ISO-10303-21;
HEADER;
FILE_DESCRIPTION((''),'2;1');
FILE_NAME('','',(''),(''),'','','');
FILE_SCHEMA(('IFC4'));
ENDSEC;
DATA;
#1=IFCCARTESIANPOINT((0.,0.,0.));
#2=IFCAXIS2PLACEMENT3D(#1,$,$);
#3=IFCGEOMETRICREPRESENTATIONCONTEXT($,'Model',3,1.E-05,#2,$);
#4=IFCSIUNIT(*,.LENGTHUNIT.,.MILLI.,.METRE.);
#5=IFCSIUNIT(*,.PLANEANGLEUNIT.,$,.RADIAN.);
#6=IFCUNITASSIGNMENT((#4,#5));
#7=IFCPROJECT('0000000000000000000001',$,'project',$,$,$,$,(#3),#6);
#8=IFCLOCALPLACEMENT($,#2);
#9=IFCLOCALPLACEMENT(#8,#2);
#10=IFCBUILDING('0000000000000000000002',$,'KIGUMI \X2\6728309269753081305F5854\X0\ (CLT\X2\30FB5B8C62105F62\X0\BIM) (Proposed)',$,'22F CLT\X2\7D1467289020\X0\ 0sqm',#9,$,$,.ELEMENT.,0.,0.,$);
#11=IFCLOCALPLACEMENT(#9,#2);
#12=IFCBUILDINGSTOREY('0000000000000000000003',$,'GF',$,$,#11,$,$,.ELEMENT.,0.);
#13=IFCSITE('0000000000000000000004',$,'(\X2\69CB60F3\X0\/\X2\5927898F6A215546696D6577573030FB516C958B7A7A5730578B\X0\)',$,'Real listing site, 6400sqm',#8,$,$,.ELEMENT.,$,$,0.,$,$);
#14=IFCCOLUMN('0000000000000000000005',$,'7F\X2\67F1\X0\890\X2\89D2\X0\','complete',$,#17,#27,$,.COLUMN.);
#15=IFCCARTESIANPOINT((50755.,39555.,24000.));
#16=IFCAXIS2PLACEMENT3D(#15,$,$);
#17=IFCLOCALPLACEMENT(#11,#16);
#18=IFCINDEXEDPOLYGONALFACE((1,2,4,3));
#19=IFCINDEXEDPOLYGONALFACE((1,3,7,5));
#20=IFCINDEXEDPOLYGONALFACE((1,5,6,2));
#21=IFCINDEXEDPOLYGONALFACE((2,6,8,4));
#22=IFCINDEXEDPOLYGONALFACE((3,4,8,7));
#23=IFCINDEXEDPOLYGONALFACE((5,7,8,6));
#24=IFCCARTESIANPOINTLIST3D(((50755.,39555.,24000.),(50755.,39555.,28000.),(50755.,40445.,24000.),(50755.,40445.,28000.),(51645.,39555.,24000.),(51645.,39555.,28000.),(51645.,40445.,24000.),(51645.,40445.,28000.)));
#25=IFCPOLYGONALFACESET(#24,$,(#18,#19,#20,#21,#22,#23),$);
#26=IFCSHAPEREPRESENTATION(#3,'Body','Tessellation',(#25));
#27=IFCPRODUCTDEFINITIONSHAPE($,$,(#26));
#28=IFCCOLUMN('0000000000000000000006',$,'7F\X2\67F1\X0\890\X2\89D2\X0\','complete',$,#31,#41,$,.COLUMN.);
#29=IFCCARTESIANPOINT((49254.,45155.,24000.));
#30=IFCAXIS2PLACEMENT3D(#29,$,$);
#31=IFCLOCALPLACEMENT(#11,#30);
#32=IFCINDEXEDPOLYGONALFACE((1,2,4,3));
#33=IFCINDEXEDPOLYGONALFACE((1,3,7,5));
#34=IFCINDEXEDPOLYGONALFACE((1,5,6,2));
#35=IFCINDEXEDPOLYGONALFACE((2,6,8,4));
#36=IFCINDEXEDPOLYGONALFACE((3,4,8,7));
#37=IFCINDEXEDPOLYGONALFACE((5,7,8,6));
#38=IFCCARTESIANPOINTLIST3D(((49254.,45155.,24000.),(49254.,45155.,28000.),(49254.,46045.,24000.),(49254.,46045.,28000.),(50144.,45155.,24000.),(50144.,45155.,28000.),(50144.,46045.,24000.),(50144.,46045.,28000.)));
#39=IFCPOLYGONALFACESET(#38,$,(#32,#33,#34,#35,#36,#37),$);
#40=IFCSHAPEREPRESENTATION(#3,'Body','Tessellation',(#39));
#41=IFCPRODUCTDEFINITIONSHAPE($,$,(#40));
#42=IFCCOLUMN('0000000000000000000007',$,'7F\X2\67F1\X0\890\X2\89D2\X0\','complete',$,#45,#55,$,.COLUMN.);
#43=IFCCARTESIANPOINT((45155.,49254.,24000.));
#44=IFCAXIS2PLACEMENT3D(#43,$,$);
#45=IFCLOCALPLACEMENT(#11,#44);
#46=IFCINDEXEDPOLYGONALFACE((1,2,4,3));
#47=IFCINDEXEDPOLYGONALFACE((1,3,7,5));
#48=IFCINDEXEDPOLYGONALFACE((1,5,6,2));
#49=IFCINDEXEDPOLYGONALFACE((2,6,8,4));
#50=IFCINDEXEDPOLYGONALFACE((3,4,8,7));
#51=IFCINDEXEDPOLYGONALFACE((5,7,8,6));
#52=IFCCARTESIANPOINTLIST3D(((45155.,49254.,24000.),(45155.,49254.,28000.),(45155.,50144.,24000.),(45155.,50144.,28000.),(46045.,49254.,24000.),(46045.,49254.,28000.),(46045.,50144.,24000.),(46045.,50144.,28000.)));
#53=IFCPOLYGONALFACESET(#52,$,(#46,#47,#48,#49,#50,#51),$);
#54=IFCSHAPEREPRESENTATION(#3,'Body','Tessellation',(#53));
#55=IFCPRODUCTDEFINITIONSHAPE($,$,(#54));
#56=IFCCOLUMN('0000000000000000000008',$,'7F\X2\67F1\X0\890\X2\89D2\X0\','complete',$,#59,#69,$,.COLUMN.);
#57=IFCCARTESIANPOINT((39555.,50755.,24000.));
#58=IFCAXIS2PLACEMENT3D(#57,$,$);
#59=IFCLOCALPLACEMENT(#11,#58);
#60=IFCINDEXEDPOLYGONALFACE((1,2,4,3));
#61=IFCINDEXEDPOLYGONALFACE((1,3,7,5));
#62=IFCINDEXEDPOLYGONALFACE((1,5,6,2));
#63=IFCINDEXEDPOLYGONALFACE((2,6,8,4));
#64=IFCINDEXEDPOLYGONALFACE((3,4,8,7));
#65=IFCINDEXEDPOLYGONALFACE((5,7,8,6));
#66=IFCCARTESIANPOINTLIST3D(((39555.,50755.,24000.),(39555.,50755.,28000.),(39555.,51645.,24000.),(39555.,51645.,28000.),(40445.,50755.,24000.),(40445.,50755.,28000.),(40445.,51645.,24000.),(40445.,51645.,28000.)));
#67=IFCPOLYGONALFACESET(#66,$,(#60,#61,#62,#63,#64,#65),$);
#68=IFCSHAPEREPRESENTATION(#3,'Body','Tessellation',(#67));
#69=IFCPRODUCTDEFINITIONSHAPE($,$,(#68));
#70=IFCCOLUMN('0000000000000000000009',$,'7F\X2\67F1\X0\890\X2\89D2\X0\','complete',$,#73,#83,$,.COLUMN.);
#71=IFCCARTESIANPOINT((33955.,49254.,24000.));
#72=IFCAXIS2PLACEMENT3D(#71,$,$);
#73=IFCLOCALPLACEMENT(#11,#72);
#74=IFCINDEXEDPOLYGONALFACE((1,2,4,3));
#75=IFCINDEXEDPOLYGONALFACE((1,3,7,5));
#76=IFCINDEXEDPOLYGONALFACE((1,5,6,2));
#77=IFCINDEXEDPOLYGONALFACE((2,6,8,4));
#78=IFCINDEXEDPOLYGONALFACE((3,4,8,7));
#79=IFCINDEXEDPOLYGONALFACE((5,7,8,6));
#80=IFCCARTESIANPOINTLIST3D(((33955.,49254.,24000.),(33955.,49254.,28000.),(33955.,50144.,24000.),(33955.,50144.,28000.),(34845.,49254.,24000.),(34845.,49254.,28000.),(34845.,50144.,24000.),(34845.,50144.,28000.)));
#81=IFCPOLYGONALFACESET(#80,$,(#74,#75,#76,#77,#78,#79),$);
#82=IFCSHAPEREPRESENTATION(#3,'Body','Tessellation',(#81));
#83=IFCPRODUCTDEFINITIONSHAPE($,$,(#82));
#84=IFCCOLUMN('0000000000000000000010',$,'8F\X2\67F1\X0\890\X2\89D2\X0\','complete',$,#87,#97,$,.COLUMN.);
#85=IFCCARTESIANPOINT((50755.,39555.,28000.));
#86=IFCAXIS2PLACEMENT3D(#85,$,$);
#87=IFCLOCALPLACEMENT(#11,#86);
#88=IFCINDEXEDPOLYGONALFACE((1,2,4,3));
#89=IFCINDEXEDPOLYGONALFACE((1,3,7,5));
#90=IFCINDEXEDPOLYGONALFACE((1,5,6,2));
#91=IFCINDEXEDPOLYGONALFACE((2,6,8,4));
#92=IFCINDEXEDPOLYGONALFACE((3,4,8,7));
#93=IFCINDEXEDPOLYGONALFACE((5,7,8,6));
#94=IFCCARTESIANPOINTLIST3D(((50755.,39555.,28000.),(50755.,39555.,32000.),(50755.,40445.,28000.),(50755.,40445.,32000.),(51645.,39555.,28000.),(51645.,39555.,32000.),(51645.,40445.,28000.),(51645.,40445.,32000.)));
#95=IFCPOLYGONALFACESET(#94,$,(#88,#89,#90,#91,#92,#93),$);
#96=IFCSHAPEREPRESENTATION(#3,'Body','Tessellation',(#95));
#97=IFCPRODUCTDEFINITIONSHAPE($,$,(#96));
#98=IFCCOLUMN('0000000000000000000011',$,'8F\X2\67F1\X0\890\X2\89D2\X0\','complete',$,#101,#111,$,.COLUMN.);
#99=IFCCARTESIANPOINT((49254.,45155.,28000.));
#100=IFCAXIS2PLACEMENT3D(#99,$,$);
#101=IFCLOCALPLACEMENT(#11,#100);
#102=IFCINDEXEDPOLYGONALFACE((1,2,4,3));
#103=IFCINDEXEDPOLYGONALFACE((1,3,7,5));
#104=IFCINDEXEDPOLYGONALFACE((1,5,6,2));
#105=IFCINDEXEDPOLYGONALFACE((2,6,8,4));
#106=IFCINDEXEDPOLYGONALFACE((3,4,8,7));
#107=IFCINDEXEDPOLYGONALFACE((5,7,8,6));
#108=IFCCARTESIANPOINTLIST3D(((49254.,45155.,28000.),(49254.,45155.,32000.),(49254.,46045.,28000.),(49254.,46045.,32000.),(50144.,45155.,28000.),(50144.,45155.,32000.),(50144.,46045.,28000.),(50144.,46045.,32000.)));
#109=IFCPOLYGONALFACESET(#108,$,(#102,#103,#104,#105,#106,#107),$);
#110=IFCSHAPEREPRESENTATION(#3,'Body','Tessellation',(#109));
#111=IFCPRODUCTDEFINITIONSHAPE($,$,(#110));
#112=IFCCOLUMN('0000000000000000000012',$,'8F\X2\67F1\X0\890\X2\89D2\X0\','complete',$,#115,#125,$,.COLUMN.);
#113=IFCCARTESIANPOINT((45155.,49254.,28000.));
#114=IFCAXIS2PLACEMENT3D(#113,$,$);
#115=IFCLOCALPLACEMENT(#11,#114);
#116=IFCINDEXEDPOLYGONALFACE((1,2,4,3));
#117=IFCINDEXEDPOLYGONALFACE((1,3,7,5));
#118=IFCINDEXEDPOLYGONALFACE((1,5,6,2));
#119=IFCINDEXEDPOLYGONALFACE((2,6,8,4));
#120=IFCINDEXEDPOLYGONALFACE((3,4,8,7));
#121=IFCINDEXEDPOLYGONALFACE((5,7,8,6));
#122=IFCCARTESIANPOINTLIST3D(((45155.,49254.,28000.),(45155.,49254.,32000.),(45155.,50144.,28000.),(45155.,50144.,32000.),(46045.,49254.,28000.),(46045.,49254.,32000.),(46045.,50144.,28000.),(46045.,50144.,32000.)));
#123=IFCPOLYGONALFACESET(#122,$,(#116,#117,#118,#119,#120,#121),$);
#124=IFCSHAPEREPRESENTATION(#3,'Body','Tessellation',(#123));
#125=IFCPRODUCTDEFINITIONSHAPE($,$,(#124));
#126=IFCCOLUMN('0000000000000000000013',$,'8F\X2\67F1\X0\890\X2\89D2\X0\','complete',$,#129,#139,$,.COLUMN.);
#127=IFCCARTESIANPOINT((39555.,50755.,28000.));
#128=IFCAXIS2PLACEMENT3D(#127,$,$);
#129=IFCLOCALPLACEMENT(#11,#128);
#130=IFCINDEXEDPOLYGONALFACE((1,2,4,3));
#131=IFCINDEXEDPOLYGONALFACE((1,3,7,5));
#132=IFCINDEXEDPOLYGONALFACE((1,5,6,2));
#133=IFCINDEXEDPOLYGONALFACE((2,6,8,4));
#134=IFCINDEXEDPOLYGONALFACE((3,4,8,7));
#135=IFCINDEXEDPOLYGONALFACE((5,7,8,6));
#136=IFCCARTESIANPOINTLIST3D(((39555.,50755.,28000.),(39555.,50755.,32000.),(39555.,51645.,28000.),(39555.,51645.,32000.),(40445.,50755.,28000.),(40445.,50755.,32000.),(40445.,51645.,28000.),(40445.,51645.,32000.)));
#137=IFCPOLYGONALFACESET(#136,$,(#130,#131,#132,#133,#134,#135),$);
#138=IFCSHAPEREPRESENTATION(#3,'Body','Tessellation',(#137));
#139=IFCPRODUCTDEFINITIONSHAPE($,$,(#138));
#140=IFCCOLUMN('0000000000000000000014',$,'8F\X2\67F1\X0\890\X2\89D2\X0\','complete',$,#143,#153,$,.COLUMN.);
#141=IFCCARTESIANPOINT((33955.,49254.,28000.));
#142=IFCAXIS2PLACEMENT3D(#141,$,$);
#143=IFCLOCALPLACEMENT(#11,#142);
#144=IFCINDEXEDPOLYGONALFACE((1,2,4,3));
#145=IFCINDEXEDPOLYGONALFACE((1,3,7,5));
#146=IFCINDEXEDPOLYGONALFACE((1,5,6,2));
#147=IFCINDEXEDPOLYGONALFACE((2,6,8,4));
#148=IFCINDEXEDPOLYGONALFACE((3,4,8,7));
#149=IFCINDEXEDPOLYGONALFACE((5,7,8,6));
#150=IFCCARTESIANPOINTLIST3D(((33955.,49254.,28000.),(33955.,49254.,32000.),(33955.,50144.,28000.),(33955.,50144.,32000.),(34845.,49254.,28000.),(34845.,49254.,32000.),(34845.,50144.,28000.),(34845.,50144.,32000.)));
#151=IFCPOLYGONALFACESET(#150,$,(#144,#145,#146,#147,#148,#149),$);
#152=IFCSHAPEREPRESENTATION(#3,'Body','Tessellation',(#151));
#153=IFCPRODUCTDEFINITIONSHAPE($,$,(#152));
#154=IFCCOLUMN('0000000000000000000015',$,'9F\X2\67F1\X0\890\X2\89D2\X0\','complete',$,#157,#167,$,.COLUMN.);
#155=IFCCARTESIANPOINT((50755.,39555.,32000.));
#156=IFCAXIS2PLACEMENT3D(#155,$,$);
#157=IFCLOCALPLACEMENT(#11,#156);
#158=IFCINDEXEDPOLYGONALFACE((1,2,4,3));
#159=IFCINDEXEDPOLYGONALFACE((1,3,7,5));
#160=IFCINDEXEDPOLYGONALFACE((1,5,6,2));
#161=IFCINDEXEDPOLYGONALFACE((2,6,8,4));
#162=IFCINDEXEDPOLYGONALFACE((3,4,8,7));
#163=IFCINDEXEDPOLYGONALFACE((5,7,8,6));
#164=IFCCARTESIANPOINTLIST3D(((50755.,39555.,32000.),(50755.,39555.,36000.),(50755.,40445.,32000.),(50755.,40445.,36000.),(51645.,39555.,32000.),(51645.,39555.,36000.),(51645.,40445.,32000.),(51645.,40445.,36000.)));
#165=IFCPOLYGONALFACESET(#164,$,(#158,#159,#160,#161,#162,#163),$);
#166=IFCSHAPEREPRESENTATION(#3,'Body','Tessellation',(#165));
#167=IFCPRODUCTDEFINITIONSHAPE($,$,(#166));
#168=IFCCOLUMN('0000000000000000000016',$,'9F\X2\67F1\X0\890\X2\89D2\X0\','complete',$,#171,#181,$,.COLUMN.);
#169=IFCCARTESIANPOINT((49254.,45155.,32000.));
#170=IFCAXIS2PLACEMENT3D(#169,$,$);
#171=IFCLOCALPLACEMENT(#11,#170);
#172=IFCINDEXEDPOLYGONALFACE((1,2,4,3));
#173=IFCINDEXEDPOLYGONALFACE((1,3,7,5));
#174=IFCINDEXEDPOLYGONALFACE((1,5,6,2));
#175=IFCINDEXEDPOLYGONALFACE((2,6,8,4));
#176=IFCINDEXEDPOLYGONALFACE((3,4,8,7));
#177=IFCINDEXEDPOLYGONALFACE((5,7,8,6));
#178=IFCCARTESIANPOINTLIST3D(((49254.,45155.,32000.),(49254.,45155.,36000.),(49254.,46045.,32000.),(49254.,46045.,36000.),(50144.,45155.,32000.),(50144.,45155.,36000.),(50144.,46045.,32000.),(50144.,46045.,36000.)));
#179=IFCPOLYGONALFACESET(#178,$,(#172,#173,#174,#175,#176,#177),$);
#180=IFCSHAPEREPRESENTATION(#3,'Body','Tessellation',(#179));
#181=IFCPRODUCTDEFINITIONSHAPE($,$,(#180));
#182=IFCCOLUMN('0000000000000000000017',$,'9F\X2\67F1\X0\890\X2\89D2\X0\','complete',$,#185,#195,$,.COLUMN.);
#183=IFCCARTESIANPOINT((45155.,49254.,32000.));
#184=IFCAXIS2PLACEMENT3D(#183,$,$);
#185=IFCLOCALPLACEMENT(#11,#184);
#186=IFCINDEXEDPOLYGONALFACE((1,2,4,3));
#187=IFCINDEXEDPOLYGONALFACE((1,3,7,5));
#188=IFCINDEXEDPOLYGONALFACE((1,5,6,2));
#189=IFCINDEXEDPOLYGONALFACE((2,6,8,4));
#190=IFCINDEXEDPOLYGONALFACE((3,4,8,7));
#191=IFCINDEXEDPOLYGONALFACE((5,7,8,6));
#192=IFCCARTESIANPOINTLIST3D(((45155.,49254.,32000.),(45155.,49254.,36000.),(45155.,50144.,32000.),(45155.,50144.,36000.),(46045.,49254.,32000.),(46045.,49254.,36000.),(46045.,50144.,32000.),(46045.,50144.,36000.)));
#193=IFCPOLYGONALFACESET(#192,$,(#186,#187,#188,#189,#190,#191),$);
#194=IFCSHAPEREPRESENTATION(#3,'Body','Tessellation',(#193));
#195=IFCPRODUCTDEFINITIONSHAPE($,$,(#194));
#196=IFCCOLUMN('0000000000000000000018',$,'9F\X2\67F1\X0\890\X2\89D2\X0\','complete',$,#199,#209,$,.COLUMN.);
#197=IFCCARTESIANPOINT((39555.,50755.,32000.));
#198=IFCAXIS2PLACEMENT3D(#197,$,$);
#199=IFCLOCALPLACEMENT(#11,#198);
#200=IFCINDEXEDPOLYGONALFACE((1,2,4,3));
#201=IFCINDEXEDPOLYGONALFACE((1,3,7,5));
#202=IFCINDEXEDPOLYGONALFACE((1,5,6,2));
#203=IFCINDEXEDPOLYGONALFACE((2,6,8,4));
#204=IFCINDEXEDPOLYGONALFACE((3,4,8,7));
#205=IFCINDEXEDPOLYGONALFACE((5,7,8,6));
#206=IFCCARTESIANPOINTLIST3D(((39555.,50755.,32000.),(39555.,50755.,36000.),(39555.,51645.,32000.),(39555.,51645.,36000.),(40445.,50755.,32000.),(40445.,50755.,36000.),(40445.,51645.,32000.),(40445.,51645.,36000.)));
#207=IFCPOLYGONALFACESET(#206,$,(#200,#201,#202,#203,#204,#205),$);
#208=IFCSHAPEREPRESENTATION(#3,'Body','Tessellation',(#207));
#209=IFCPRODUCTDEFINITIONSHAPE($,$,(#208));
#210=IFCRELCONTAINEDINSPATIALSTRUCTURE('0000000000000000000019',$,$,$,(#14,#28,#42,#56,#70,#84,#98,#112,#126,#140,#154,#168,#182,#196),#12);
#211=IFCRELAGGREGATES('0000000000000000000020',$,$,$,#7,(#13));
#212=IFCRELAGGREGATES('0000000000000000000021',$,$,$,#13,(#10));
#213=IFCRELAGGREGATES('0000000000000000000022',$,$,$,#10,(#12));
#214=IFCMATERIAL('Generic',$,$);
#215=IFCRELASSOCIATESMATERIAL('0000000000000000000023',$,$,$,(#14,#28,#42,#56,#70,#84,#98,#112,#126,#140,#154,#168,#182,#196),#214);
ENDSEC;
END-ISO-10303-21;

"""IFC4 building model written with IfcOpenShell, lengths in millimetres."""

from ifc_helpers import new_model, si_unit, frame, frame_2d, origin, place, context, project, spatial, rectangle, extrude, material, element, save


model = new_model("IFC4")

# Units and contexts
model_context = context("Model", 3, precision=1e-05, world=origin())
ifc_project = project(units=[si_unit("LENGTHUNIT", "METRE", prefix="MILLI"), si_unit("PLANEANGLEUNIT", "RADIAN")], contexts=[model_context])

# Site, building, storey
site_placement = place(None, origin())
site = spatial("IfcSite", under=ifc_project, at=site_placement, Name="(構想/大規模商業敷地・公開空地型)", ObjectType="Real listing site, 6400sqm", CompositionType="ELEMENT", RefElevation=0.0)
building_placement = place(site_placement, origin())
building = spatial("IfcBuilding", under=site, at=building_placement, Name="KIGUMI 木を極めた塔 (CLT・完成形BIM) (Proposed)", ObjectType="22F CLT純木造 0sqm", CompositionType="ELEMENT", ElevationOfRefHeight=0.0, ElevationOfTerrain=0.0)
storey_placement = place(building_placement, origin())
storey = spatial("IfcBuildingStorey", under=building, at=storey_placement, Name="GF", CompositionType="ELEMENT", Elevation=0.0)

# Columns
ifc_material = material(Name="Generic")
column_1_placement = place(storey_placement, frame((50755.0, 39555.0, 24000.0)))
element("IfcColumn", 1, at=column_1_placement, inside=storey, material=ifc_material, Name="7F柱890角", Description="complete", PredefinedType="COLUMN", context=model_context, shape_type="SweptSolid", body=[
    extrude(rectangle(XDim=890.0, YDim=890.0, at=frame_2d((445.0, 445.0))), frame((50755.0, 39555.0, 24000.0)), (0.0, 0.0, 1.0), 4000.0),
])
column_2_placement = place(storey_placement, frame((49254.0, 45155.0, 24000.0)))
element("IfcColumn", 2, at=column_2_placement, inside=storey, material=ifc_material, Name="7F柱890角", Description="complete", PredefinedType="COLUMN", context=model_context, shape_type="SweptSolid", body=[
    extrude(rectangle(XDim=890.0, YDim=890.0, at=frame_2d((445.0, 445.0))), frame((49254.0, 45155.0, 24000.0)), (0.0, 0.0, 1.0), 4000.0),
])
column_3_placement = place(storey_placement, frame((45155.0, 49254.0, 24000.0)))
element("IfcColumn", 3, at=column_3_placement, inside=storey, material=ifc_material, Name="7F柱890角", Description="complete", PredefinedType="COLUMN", context=model_context, shape_type="SweptSolid", body=[
    extrude(rectangle(XDim=890.0, YDim=890.0, at=frame_2d((445.0, 445.0))), frame((45155.0, 49254.0, 24000.0)), (0.0, 0.0, 1.0), 4000.0),
])
column_4_placement = place(storey_placement, frame((39555.0, 50755.0, 24000.0)))
element("IfcColumn", 4, at=column_4_placement, inside=storey, material=ifc_material, Name="7F柱890角", Description="complete", PredefinedType="COLUMN", context=model_context, shape_type="SweptSolid", body=[
    extrude(rectangle(XDim=890.0, YDim=890.0, at=frame_2d((445.0, 445.0))), frame((39555.0, 50755.0, 24000.0)), (0.0, 0.0, 1.0), 4000.0),
])
column_5_placement = place(storey_placement, frame((33955.0, 49254.0, 24000.0)))
element("IfcColumn", 5, at=column_5_placement, inside=storey, material=ifc_material, Name="7F柱890角", Description="complete", PredefinedType="COLUMN", context=model_context, shape_type="SweptSolid", body=[
    extrude(rectangle(XDim=890.0, YDim=890.0, at=frame_2d((445.0, 445.0))), frame((33955.0, 49254.0, 24000.0)), (0.0, 0.0, 1.0), 4000.0),
])
column_6_placement = place(storey_placement, frame((50755.0, 39555.0, 28000.0)))
element("IfcColumn", 6, at=column_6_placement, inside=storey, material=ifc_material, Name="8F柱890角", Description="complete", PredefinedType="COLUMN", context=model_context, shape_type="SweptSolid", body=[
    extrude(rectangle(XDim=890.0, YDim=890.0, at=frame_2d((445.0, 445.0))), frame((50755.0, 39555.0, 28000.0)), (0.0, 0.0, 1.0), 4000.0),
])
column_7_placement = place(storey_placement, frame((49254.0, 45155.0, 28000.0)))
element("IfcColumn", 7, at=column_7_placement, inside=storey, material=ifc_material, Name="8F柱890角", Description="complete", PredefinedType="COLUMN", context=model_context, shape_type="SweptSolid", body=[
    extrude(rectangle(XDim=890.0, YDim=890.0, at=frame_2d((445.0, 445.0))), frame((49254.0, 45155.0, 28000.0)), (0.0, 0.0, 1.0), 4000.0),
])
column_8_placement = place(storey_placement, frame((45155.0, 49254.0, 28000.0)))
element("IfcColumn", 8, at=column_8_placement, inside=storey, material=ifc_material, Name="8F柱890角", Description="complete", PredefinedType="COLUMN", context=model_context, shape_type="SweptSolid", body=[
    extrude(rectangle(XDim=890.0, YDim=890.0, at=frame_2d((445.0, 445.0))), frame((45155.0, 49254.0, 28000.0)), (0.0, 0.0, 1.0), 4000.0),
])
column_9_placement = place(storey_placement, frame((39555.0, 50755.0, 28000.0)))
element("IfcColumn", 9, at=column_9_placement, inside=storey, material=ifc_material, Name="8F柱890角", Description="complete", PredefinedType="COLUMN", context=model_context, shape_type="SweptSolid", body=[
    extrude(rectangle(XDim=890.0, YDim=890.0, at=frame_2d((445.0, 445.0))), frame((39555.0, 50755.0, 28000.0)), (0.0, 0.0, 1.0), 4000.0),
])
column_10_placement = place(storey_placement, frame((33955.0, 49254.0, 28000.0)))
element("IfcColumn", 10, at=column_10_placement, inside=storey, material=ifc_material, Name="8F柱890角", Description="complete", PredefinedType="COLUMN", context=model_context, shape_type="SweptSolid", body=[
    extrude(rectangle(XDim=890.0, YDim=890.0, at=frame_2d((445.0, 445.0))), frame((33955.0, 49254.0, 28000.0)), (0.0, 0.0, 1.0), 4000.0),
])
column_11_placement = place(storey_placement, frame((50755.0, 39555.0, 32000.0)))
element("IfcColumn", 11, at=column_11_placement, inside=storey, material=ifc_material, Name="9F柱890角", Description="complete", PredefinedType="COLUMN", context=model_context, shape_type="SweptSolid", body=[
    extrude(rectangle(XDim=890.0, YDim=890.0, at=frame_2d((445.0, 445.0))), frame((50755.0, 39555.0, 32000.0)), (0.0, 0.0, 1.0), 4000.0),
])
column_12_placement = place(storey_placement, frame((49254.0, 45155.0, 32000.0)))
element("IfcColumn", 12, at=column_12_placement, inside=storey, material=ifc_material, Name="9F柱890角", Description="complete", PredefinedType="COLUMN", context=model_context, shape_type="SweptSolid", body=[
    extrude(rectangle(XDim=890.0, YDim=890.0, at=frame_2d((445.0, 445.0))), frame((49254.0, 45155.0, 32000.0)), (0.0, 0.0, 1.0), 4000.0),
])
column_13_placement = place(storey_placement, frame((45155.0, 49254.0, 32000.0)))
element("IfcColumn", 13, at=column_13_placement, inside=storey, material=ifc_material, Name="9F柱890角", Description="complete", PredefinedType="COLUMN", context=model_context, shape_type="SweptSolid", body=[
    extrude(rectangle(XDim=890.0, YDim=890.0, at=frame_2d((445.0, 445.0))), frame((45155.0, 49254.0, 32000.0)), (0.0, 0.0, 1.0), 4000.0),
])
column_14_placement = place(storey_placement, frame((39555.0, 50755.0, 32000.0)))
element("IfcColumn", 14, at=column_14_placement, inside=storey, material=ifc_material, Name="9F柱890角", Description="complete", PredefinedType="COLUMN", context=model_context, shape_type="SweptSolid", body=[
    extrude(rectangle(XDim=890.0, YDim=890.0, at=frame_2d((445.0, 445.0))), frame((39555.0, 50755.0, 32000.0)), (0.0, 0.0, 1.0), 4000.0),
])

save(model, "model.ifc")
